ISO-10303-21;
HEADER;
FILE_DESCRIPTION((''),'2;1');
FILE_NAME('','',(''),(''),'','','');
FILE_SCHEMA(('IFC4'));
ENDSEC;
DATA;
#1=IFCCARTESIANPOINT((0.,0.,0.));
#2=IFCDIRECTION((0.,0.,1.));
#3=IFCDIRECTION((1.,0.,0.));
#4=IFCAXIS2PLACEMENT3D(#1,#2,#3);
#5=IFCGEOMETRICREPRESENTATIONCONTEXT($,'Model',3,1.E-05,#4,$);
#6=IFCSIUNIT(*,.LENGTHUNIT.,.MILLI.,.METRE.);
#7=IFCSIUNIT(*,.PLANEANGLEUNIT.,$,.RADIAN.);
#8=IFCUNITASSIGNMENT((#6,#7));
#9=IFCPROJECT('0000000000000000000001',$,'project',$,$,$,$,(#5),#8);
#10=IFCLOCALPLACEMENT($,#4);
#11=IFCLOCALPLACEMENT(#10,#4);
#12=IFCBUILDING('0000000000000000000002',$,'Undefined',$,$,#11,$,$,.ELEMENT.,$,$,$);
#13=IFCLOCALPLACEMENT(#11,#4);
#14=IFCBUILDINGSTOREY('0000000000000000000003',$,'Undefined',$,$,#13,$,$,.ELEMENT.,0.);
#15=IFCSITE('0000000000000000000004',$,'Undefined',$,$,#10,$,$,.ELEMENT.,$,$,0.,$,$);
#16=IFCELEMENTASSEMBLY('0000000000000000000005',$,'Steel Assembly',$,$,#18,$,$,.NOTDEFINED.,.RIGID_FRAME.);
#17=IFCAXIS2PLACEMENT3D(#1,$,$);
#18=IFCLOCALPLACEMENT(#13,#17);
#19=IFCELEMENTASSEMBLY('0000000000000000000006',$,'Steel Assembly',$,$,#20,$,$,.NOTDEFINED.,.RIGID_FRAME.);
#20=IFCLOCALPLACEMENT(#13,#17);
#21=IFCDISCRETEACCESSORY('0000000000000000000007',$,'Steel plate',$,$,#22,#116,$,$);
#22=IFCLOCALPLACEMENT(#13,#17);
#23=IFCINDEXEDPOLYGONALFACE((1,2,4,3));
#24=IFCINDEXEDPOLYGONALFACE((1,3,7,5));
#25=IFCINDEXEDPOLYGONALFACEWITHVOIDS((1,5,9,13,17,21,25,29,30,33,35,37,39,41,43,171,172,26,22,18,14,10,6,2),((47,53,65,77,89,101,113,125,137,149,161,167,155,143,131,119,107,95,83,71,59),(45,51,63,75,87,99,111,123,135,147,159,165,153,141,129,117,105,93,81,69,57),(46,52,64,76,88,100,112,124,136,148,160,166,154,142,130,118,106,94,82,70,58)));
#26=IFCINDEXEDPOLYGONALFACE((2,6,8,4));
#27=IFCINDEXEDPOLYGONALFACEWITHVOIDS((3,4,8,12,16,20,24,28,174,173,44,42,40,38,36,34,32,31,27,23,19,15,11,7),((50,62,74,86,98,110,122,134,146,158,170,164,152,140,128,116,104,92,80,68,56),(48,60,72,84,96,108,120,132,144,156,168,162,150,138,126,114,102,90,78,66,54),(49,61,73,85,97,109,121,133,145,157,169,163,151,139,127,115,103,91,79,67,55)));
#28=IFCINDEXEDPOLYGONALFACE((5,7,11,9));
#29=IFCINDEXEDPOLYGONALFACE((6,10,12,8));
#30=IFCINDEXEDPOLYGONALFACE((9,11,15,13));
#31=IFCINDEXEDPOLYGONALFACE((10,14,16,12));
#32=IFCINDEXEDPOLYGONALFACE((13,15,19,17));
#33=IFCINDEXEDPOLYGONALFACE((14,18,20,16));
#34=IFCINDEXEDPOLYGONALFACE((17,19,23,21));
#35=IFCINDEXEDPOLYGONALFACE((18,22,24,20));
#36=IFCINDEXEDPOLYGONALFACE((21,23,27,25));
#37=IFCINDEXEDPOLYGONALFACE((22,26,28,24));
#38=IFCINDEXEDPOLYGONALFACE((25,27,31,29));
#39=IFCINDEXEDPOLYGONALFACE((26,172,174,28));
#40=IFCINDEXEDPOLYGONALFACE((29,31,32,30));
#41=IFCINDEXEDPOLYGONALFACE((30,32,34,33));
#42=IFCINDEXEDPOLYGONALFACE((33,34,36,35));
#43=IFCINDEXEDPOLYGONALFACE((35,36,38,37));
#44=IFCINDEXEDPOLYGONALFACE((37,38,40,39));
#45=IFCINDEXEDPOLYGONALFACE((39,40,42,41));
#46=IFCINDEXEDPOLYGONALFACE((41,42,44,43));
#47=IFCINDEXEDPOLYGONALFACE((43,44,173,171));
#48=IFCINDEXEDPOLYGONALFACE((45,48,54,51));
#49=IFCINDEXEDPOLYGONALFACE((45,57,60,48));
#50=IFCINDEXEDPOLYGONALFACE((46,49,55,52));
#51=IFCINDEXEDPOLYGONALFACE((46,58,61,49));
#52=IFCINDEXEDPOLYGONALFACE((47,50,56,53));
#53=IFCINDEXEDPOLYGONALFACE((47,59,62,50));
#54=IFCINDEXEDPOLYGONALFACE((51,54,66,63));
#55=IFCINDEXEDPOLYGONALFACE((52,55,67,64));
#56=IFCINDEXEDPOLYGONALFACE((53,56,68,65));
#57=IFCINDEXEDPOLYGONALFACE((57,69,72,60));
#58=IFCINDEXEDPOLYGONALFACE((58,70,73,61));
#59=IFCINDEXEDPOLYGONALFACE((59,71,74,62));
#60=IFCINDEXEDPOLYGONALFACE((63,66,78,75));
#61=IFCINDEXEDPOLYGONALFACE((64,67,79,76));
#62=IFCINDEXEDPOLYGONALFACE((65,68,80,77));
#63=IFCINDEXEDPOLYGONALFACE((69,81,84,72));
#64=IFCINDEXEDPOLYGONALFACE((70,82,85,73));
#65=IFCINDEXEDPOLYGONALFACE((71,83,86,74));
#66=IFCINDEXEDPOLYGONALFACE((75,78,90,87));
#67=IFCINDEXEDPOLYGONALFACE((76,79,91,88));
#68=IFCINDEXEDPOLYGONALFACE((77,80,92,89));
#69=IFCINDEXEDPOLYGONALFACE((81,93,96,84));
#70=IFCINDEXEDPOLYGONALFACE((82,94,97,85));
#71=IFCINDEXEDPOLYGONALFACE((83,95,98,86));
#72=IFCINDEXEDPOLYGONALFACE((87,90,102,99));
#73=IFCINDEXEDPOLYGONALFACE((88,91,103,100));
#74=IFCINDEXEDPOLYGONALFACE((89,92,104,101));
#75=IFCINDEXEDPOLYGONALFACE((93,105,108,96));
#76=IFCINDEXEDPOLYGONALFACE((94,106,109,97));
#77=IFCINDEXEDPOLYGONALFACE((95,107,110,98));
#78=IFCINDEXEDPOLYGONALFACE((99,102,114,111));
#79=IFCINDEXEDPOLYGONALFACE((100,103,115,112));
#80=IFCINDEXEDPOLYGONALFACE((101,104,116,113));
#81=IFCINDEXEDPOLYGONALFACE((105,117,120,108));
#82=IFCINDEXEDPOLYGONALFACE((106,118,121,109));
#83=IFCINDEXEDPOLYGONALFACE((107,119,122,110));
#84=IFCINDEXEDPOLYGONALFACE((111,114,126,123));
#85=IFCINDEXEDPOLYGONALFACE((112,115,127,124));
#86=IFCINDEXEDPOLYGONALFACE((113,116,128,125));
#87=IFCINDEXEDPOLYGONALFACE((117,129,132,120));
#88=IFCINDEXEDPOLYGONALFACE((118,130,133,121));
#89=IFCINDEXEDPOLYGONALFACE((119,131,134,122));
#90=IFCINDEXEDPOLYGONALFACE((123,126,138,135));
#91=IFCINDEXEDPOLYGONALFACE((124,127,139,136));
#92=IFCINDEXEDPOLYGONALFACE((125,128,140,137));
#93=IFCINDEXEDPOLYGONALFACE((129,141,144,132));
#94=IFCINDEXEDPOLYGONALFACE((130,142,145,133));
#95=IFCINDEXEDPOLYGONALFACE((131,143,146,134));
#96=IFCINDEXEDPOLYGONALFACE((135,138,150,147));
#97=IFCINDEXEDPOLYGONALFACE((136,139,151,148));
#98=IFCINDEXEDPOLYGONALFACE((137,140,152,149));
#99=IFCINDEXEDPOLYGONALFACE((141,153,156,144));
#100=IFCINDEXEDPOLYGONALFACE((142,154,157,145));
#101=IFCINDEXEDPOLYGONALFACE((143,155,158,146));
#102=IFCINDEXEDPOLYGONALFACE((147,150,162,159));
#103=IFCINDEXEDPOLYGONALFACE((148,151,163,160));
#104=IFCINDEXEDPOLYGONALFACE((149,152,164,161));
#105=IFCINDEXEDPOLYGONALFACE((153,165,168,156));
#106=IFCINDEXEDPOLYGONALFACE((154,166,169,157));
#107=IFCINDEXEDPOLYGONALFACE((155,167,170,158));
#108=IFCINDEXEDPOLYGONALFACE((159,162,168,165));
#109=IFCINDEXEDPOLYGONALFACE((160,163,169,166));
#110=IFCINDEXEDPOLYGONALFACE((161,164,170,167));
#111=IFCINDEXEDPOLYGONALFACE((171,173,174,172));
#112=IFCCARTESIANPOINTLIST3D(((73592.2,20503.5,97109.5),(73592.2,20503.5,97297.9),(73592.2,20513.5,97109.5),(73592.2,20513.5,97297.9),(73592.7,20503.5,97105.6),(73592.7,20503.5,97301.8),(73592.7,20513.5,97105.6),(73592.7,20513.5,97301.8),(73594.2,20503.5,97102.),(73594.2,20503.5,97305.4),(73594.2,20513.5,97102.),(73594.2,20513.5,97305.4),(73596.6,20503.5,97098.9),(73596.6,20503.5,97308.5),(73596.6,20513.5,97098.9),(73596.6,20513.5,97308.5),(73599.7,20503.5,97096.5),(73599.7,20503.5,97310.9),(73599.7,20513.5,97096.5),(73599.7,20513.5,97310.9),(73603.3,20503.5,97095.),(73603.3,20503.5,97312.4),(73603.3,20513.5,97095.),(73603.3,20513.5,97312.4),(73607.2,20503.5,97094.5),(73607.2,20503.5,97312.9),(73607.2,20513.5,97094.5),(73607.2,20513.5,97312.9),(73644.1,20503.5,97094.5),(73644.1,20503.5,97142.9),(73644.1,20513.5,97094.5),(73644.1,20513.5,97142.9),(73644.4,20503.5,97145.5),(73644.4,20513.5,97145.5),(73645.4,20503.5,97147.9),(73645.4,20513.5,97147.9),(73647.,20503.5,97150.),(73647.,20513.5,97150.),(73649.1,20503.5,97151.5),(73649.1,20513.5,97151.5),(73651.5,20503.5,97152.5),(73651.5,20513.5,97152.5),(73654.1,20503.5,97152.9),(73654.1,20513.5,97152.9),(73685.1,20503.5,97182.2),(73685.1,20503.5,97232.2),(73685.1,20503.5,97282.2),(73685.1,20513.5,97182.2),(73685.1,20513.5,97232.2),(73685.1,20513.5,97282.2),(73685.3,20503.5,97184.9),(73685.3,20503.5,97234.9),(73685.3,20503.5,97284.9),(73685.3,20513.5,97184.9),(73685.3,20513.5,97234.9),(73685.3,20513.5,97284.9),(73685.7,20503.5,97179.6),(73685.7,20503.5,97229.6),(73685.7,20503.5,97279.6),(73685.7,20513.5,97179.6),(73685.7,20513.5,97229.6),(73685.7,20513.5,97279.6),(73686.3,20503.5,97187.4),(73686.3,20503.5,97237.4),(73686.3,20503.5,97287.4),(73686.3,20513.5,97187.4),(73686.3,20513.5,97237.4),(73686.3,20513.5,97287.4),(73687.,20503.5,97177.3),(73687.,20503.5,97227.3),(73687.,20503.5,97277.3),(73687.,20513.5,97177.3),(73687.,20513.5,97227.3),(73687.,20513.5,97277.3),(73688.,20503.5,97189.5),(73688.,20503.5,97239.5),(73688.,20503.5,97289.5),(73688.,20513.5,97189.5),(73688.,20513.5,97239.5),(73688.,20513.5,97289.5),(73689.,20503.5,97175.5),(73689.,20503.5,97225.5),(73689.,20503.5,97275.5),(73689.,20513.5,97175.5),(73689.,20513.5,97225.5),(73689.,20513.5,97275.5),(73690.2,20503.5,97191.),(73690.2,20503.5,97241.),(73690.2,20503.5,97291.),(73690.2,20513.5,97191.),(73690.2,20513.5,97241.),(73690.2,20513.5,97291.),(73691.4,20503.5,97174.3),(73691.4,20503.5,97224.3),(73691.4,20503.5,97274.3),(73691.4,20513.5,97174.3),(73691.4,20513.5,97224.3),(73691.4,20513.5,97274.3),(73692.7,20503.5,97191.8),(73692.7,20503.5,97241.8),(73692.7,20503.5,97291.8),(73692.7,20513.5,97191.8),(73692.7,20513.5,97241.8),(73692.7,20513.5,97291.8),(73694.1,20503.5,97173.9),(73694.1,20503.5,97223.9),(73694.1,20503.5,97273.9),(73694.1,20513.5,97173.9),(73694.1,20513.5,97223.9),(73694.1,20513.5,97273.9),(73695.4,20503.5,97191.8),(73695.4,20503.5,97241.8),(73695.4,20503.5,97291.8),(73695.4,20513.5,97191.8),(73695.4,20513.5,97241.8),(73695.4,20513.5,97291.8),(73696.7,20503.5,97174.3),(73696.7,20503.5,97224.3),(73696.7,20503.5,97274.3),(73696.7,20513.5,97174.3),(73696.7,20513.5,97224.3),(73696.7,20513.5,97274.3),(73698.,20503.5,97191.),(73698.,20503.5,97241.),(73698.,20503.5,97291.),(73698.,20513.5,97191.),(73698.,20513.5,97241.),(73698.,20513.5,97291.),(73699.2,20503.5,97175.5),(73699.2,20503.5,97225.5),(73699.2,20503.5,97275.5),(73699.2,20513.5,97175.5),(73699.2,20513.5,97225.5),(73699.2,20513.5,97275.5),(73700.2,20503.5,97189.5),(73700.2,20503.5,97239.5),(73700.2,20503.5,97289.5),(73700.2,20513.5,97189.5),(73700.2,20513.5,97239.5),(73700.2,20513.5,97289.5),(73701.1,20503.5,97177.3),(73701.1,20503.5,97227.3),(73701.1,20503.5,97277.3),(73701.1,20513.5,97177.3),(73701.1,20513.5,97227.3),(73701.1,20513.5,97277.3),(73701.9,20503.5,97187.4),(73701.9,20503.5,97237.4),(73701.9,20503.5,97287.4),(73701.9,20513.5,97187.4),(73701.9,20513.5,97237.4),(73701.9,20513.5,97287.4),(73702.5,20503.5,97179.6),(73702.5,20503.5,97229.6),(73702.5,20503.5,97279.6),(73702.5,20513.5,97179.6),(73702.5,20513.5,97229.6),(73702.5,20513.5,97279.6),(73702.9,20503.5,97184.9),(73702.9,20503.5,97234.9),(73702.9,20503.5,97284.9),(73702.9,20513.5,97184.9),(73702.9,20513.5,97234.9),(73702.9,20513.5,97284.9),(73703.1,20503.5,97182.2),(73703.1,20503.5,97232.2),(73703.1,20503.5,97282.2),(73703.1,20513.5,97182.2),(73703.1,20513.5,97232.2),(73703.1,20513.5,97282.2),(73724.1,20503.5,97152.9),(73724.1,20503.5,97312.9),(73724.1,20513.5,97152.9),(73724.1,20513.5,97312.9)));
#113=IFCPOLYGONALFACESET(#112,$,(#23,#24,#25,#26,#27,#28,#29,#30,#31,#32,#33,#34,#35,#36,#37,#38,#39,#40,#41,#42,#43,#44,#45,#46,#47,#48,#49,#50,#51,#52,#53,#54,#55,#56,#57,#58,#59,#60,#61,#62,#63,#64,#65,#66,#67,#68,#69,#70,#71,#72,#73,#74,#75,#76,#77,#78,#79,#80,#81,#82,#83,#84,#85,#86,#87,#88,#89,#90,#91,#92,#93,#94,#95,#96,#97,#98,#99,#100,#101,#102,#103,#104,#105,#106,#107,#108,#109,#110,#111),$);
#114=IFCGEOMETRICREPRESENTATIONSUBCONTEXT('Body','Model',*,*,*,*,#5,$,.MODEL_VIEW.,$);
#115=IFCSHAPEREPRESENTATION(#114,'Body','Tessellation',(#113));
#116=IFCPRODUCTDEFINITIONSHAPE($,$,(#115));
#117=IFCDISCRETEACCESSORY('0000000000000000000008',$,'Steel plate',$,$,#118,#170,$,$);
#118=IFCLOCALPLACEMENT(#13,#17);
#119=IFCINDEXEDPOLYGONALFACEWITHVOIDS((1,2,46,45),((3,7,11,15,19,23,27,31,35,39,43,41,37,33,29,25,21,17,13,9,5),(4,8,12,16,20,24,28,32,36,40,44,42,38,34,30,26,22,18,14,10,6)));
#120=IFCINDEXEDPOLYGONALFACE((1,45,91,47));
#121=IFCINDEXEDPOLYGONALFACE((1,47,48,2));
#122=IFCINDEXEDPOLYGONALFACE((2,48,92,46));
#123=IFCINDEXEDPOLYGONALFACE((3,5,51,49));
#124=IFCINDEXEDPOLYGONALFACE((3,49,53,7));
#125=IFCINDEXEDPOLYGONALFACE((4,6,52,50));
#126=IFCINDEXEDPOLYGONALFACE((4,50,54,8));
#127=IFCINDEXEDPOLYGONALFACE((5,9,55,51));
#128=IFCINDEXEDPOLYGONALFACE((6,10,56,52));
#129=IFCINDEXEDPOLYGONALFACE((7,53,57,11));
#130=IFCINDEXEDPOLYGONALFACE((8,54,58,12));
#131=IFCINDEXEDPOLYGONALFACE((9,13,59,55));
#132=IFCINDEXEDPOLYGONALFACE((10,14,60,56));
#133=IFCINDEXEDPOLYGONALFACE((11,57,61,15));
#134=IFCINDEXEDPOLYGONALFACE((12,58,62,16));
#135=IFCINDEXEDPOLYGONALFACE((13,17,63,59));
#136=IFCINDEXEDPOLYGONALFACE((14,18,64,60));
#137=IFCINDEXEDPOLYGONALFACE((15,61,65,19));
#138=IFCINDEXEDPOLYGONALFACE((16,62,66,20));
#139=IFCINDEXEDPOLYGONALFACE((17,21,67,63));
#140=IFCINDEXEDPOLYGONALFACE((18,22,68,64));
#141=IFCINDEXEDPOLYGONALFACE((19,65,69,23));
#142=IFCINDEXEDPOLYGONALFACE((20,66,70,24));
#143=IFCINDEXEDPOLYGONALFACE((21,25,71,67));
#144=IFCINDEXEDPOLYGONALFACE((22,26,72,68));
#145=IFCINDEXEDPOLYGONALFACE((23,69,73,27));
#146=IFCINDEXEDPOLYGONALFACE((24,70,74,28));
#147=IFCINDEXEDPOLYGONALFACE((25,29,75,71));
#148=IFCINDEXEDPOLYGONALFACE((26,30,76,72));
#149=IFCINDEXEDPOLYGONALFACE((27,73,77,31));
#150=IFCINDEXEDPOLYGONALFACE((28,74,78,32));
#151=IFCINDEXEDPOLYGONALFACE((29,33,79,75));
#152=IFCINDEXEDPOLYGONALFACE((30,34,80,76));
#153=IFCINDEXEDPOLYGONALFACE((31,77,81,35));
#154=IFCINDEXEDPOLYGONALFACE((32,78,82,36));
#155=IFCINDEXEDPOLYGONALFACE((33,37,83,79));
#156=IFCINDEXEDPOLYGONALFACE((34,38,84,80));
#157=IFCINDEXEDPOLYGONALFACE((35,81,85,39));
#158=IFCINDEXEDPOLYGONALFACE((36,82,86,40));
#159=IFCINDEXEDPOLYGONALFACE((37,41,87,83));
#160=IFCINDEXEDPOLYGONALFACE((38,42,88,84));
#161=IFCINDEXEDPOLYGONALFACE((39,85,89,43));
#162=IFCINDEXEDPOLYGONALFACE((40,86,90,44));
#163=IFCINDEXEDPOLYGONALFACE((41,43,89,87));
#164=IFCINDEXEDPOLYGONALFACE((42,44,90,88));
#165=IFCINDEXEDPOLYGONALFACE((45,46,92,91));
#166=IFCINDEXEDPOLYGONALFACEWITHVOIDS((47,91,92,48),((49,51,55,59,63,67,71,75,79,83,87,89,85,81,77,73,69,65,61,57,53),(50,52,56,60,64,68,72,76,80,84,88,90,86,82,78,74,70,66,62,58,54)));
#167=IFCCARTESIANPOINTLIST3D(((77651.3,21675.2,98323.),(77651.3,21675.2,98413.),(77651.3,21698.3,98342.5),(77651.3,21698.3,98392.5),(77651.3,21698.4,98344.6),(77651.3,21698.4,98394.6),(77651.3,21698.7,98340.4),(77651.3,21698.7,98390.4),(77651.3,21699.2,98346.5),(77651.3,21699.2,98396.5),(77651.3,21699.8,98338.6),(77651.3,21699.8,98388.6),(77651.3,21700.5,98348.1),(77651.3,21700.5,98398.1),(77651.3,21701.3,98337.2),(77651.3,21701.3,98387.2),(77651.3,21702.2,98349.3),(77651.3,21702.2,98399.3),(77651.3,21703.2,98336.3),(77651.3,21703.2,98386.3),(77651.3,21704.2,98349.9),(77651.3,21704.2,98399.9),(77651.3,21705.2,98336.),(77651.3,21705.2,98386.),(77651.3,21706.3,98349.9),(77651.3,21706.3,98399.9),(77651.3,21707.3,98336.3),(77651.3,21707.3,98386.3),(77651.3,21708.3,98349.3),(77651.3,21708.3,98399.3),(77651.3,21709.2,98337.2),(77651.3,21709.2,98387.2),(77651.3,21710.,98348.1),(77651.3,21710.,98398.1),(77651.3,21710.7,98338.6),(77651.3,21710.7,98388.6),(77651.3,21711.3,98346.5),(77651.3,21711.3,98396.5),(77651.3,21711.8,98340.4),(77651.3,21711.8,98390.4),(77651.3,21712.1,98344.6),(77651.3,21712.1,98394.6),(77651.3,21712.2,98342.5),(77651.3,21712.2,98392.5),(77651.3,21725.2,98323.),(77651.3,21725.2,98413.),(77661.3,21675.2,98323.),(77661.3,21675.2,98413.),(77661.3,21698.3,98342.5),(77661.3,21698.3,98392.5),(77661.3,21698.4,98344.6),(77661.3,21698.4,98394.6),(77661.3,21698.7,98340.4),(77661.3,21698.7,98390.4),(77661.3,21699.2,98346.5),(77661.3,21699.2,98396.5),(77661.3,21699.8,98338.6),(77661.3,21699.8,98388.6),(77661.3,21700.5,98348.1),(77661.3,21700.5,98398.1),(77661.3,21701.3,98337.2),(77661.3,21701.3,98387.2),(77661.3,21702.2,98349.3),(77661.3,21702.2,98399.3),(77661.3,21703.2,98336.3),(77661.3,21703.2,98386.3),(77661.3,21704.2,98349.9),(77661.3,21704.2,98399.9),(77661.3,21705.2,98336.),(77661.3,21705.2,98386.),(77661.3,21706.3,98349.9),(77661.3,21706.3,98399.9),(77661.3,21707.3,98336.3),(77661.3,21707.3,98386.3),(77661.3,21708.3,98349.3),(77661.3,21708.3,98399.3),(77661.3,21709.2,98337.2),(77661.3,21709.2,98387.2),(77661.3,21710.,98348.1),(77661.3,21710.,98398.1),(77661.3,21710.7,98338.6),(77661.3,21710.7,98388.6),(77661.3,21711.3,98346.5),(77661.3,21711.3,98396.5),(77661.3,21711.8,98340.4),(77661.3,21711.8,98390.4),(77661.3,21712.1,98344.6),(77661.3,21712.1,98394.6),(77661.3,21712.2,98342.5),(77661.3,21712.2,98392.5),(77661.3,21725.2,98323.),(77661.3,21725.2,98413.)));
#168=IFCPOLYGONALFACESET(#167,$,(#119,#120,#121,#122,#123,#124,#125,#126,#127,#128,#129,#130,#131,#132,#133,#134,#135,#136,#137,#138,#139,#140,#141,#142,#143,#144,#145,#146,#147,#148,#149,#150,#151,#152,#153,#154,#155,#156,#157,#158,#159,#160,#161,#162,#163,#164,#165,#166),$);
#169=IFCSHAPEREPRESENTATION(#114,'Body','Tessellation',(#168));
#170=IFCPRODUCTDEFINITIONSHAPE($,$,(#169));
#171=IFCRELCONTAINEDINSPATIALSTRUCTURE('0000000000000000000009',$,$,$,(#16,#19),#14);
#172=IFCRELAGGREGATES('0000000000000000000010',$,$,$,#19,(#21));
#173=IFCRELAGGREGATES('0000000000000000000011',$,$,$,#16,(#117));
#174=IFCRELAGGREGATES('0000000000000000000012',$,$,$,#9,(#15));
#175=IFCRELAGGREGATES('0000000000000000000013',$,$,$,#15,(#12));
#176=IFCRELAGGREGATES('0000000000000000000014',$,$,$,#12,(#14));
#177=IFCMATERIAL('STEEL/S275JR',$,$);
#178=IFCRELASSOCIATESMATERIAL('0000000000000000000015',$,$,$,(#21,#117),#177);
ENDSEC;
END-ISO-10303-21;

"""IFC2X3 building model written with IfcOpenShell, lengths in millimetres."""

from ifc_helpers import new_model, si_unit, frame, frame_2d, origin_with_axes, origin_2d_with_axis, place, context, subcontext, project, spatial, polyline, circle_curve, parameter, trimmed, segment, composite_curve, circle, outline, extrude, source, transform, mapped, material, element, aggregate, save


model = new_model("IFC2X3")

# Units and contexts
model_context = context("Model", 3, precision=1e-05, world=origin_with_axes())
body_context = subcontext(model_context, "Body", "Model", "MODEL_VIEW")
ifc_project = project(units=[si_unit("LENGTHUNIT", "METRE", prefix="MILLI"), si_unit("PLANEANGLEUNIT", "RADIAN")], contexts=[model_context])

# Site, building, storey
site_placement = place(None, origin_with_axes())
site = spatial("IfcSite", under=ifc_project, at=site_placement, Name="Undefined", CompositionType="ELEMENT", RefElevation=0.0)
building_placement = place(site_placement, origin_with_axes())
building = spatial("IfcBuilding", under=site, at=building_placement, Name="Undefined", CompositionType="ELEMENT")
storey_placement = place(building_placement, origin_with_axes())
storey = spatial("IfcBuildingStorey", under=building, at=storey_placement, Name="Undefined", CompositionType="ELEMENT", Elevation=0.0)

# Element assembly
assembly_1_placement = place(storey_placement, origin_with_axes())
assembly_1 = element("IfcElementAssembly", 1, at=assembly_1_placement, inside=storey, Name="Steel Assembly", AssemblyPlace="NOTDEFINED", PredefinedType="RIGID_FRAME")

# Element assembly
assembly_2_placement = place(storey_placement, origin_with_axes())
assembly_2 = element("IfcElementAssembly", 2, at=assembly_2_placement, inside=storey, Name="Steel Assembly", AssemblyPlace="NOTDEFINED", PredefinedType="RIGID_FRAME")
ifc_material_1 = material(Name="STEEL/S275JR")

# Discrete accessories, openings
shared_shape_1 = source(origin_with_axes(), body_context, "Body", "SweptSolid", [
    extrude(circle(Radius=9.0, at=origin_2d_with_axis()), frame((0.0, -0.1, 0.0), z_axis=(0.0, 1.0, 0.0), x_axis=(1.0, 0.0, 0.0)), (0.0, 0.0, 1.0), 10.2),
])
discrete_accessory_1_placement = place(assembly_2_placement, frame((73592.2, 20508.5, 97312.9), z_axis=(0.0, 1.0, 0.0), x_axis=(1.0, 0.0, 0.0)))
discrete_accessory_1 = element("IfcDiscreteAccessory", 3, at=discrete_accessory_1_placement, material=ifc_material_1, Name="Steel plate", context=body_context, shape_type="SweptSolid", body=[
    extrude(outline(composite_curve([segment(trimmed(circle_curve(frame_2d((15.0, 15.0), x_axis=(-1.0, 0.0)), 15.0), [parameter(0.0)], [parameter(1.570796)], True, "PARAMETER"), True, "CONTINUOUS"), segment(polyline([(15.0, 0.0), (131.9, 0.0), (131.9, 160.0), (61.9, 160.0)]), True, "CONTINUOUS"), segment(trimmed(circle_curve(frame_2d((61.9, 170.0), x_axis=(0.0, -1.0)), 10.0), [parameter(0.0)], [parameter(4.712389)], False, "PARAMETER"), True, "CONTINUOUS"), segment(polyline([(51.9, 170.0), (51.9, 218.4), (15.0, 218.4)]), True, "CONTINUOUS"), segment(trimmed(circle_curve(frame_2d((15.0, 203.4), x_axis=(0.0, 1.0)), 15.0), [parameter(0.0)], [parameter(1.570796)], True, "PARAMETER"), True, "CONTINUOUS"), segment(polyline([(0.0, 203.4), (0.0, 15.0)]), True, "DISCONTINUOUS")], self_intersect=False)), frame((0.0, 0.0, -5.0), z_axis=(0.0, 0.0, 1.0), x_axis=(1.0, 0.0, 0.0)), (0.0, 0.0, 1.0), 10.0),
])
opening_1_placement = place(assembly_2_placement, frame((73694.1, 20513.5, 97282.9), z_axis=(-1.0, 0.0, 0.0), x_axis=(0.0, 0.0, -1.0)))
element("IfcOpeningElement", 4, at=opening_1_placement, cuts=discrete_accessory_1, ObjectType="Opening", context=body_context, shape_type="MappedRepresentation", body=[
    mapped(shared_shape_1, transform((0.0, 0.0, 0.0))),
    mapped(shared_shape_1, transform((50.0, 0.0, 0.0))),
    mapped(shared_shape_1, transform((100.0, 0.0, 0.0))),
])
aggregate(assembly_2, [discrete_accessory_1])
discrete_accessory_2_placement = place(assembly_1_placement, frame((77656.3, 21675.2, 98323.0), z_axis=(-1.0, 0.0, 0.0), x_axis=(0.0, 0.0, 1.0)))
discrete_accessory_2 = element("IfcDiscreteAccessory", 5, at=discrete_accessory_2_placement, material=ifc_material_1, Name="Steel plate", context=body_context, shape_type="SweptSolid", body=[
    extrude(outline(polyline([(0.0, 0.0), (90.0, 0.0), (90.0, 50.0), (0.0, 50.0), (0.0, 0.0)])), frame((0.0, 0.0, -5.0), z_axis=(0.0, 0.0, 1.0), x_axis=(1.0, 0.0, 0.0)), (0.0, 0.0, 1.0), 10.0),
])
shared_shape_2 = source(origin_with_axes(), body_context, "Body", "SweptSolid", [
    extrude(circle(Radius=7.0, at=origin_2d_with_axis()), frame((0.0, -10.1, 0.0), z_axis=(0.0, 1.0, 0.0), x_axis=(1.0, 0.0, 0.0)), (0.0, 0.0, 1.0), 20.3),
])
opening_2_placement = place(assembly_1_placement, frame((77651.3, 21705.2, 98393.0), z_axis=(0.0, 1.0, 0.0), x_axis=(0.0, 0.0, -1.0)))
element("IfcOpeningElement", 6, at=opening_2_placement, cuts=discrete_accessory_2, ObjectType="Opening", context=body_context, shape_type="MappedRepresentation", body=[
    mapped(shared_shape_2, transform((0.0, 0.0, 0.0))),
    mapped(shared_shape_2, transform((50.0, 0.0, 0.0))),
])
aggregate(assembly_1, [discrete_accessory_2])

save(model, "model.ifc")
